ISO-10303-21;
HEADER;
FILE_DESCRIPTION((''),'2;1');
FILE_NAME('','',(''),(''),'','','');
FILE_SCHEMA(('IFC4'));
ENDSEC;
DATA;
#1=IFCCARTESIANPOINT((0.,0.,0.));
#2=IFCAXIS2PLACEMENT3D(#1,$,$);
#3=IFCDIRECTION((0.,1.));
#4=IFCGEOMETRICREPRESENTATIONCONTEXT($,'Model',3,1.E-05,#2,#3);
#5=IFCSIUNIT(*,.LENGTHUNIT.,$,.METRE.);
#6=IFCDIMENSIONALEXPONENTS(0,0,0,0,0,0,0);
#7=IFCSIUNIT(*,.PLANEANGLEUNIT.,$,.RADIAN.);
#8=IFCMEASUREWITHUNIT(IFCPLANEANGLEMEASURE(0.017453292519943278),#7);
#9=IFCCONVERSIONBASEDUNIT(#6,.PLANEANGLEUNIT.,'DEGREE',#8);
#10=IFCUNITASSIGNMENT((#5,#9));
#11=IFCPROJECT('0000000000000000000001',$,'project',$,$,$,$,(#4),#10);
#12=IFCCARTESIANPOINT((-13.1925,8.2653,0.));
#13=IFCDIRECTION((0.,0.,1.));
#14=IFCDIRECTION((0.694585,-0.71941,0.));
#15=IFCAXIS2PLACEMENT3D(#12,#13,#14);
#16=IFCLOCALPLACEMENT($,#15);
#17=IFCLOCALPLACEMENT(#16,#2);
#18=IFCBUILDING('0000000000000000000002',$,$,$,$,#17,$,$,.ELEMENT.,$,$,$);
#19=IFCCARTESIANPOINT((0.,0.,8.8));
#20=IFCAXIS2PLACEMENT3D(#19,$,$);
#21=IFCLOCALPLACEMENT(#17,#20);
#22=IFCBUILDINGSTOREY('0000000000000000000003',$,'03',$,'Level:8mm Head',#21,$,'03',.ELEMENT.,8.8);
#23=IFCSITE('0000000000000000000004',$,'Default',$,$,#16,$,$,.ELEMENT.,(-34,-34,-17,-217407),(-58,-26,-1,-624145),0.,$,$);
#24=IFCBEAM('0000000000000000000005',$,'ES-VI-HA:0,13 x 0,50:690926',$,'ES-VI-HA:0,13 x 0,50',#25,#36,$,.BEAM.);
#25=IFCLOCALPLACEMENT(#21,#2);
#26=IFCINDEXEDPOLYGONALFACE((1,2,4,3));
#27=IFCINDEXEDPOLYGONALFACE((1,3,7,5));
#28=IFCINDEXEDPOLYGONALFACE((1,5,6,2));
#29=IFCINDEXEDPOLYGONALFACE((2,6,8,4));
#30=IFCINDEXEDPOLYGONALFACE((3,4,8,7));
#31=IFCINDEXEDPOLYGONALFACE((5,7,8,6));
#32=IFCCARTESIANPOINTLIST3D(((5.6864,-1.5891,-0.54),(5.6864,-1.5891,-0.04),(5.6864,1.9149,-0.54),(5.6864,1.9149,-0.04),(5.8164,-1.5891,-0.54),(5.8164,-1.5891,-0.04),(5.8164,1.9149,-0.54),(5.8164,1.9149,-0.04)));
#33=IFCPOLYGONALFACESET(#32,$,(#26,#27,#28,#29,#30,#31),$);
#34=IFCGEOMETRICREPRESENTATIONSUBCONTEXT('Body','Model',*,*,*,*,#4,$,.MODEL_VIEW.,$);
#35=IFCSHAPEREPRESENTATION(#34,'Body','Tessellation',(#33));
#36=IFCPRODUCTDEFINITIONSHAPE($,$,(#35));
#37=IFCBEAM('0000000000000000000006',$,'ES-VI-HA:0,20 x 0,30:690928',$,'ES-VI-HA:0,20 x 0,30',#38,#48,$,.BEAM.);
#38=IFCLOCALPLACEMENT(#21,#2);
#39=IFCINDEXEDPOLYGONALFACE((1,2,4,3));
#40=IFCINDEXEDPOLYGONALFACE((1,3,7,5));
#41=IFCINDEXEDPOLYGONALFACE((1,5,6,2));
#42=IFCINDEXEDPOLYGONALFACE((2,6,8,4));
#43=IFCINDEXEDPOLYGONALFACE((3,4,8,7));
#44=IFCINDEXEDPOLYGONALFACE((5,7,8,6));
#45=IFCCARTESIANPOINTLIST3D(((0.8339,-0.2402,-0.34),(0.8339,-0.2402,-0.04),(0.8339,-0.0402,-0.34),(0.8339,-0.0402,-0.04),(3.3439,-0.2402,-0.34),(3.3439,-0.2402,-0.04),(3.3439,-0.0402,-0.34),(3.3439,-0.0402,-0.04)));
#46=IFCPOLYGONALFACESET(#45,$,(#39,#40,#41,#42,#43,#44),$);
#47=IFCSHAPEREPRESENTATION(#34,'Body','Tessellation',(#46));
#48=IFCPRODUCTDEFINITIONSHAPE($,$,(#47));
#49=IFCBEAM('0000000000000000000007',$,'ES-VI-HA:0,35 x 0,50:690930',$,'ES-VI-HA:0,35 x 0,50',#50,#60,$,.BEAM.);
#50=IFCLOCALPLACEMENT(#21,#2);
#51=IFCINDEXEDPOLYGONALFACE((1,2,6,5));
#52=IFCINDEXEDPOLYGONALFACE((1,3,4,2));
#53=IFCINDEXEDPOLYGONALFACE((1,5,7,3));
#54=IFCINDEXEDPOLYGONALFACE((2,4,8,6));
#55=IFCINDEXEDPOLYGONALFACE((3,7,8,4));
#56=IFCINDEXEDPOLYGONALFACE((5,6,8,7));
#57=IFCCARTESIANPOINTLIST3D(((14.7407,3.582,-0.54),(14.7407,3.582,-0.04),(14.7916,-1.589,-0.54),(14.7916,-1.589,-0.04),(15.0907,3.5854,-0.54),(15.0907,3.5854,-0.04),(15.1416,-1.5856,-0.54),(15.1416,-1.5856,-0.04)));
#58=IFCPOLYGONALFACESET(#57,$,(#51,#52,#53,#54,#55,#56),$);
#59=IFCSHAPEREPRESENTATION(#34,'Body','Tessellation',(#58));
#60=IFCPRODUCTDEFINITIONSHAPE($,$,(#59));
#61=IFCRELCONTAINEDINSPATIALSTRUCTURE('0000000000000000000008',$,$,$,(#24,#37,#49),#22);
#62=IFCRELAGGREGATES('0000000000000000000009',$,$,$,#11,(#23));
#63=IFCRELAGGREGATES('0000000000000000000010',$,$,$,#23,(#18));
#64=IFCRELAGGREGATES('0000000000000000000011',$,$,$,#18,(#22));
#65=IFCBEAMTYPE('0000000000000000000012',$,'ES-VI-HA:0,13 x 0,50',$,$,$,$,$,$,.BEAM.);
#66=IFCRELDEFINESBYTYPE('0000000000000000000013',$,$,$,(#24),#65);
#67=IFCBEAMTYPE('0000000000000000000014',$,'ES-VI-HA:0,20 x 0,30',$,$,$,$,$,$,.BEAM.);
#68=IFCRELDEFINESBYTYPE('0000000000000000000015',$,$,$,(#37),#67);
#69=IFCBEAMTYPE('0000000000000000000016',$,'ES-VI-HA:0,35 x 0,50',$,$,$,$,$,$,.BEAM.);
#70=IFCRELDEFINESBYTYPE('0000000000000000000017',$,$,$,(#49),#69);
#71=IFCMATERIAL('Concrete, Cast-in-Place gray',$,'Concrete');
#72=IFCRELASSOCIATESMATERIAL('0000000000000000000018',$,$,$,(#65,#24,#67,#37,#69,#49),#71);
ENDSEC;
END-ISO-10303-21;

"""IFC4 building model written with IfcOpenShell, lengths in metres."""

from ifc_helpers import new_model, entity, si_unit, converted_unit, direction, frame, origin, place, context, subcontext, project, spatial, indexed_curve, outline, extrude, source, transform, mapped, material, type_object, type_shapes, element, save


model = new_model("IFC4")

# Units and contexts
model_context = context("Model", 3, precision=1e-05, world=origin(), true_north=direction((0.0, 1.0)))
body_context = subcontext(model_context, "Body", "Model", "MODEL_VIEW")
ifc_project = project(units=[si_unit("LENGTHUNIT", "METRE"), converted_unit("PLANEANGLEUNIT", "DEGREE", entity("IfcPlaneAngleMeasure", 0.017453292519943278), si_unit("PLANEANGLEUNIT", "RADIAN"), dimensions=[0, 0, 0, 0, 0, 0, 0])], contexts=[model_context])

# Site, building, storey
site_placement = place(None, frame((-13.1925, 8.2653, 0.0), z_axis=(0.0, 0.0, 1.0), x_axis=(0.694585, -0.71941, 0.0)))
site = spatial("IfcSite", under=ifc_project, at=site_placement, Name="Default", CompositionType="ELEMENT", RefLatitude=(-34, -34, -17, -217407), RefLongitude=(-58, -26, -1, -624145), RefElevation=0.0)
building_placement = place(site_placement, origin())
building = spatial("IfcBuilding", under=site, at=building_placement, CompositionType="ELEMENT")
storey_placement = place(building_placement, frame((0.0, 0.0, 8.8)))
storey = spatial("IfcBuildingStorey", under=building, at=storey_placement, Name="03", ObjectType="Level:8mm Head", LongName="03", CompositionType="ELEMENT", Elevation=8.8)

# Beams
ifc_material = material(Name="Concrete, Cast-in-Place gray", Category="Concrete")
beam_type_1 = type_object("IfcBeamType", Name="ES-VI-HA:0,13 x 0,50", PredefinedType="BEAM", material=ifc_material)
shared_shape_1 = source(origin(), body_context, "Body", "SweptSolid", [
    extrude(outline(indexed_curve([(-0.065, -0.25), (0.065, -0.25), (0.065, 0.25), (-0.065, 0.25), (-0.065, -0.25)], self_intersect=False)), frame((5.7514, -1.5891, 8.51), z_axis=(0.0, 1.0, 0.0), x_axis=(-1.0, 0.0, 0.0)), (0.0, 0.0, 1.0), 3.5039),
])
type_shapes(beam_type_1, [shared_shape_1])
beam_1_placement = place(storey_placement, frame((0.0, 0.0, -8.8)))
element("IfcBeam", 1, at=beam_1_placement, inside=storey, type_object=beam_type_1, material=ifc_material, Name="ES-VI-HA:0,13 x 0,50:690926", ObjectType="ES-VI-HA:0,13 x 0,50", PredefinedType="BEAM", context=body_context, shape_type="MappedRepresentation", body=[
    mapped(shared_shape_1, transform((0.0, 0.0, 0.0), scale=1.0)),
])
beam_type_2 = type_object("IfcBeamType", Name="ES-VI-HA:0,20 x 0,30", PredefinedType="BEAM", material=ifc_material)
shared_shape_2 = source(origin(), body_context, "Body", "SweptSolid", [
    extrude(outline(indexed_curve([(-0.15, -0.1), (0.15, -0.1), (0.15, 0.1), (-0.15, 0.1), (-0.15, -0.1)], self_intersect=False)), frame((0.8339, -0.1402, 8.61), z_axis=(1.0, 0.0, 0.0), x_axis=(0.0, 0.0, -1.0)), (0.0, 0.0, 1.0), 2.51),
])
type_shapes(beam_type_2, [shared_shape_2])
beam_2_placement = place(storey_placement, frame((0.0, 0.0, -8.8)))
element("IfcBeam", 2, at=beam_2_placement, inside=storey, type_object=beam_type_2, material=ifc_material, Name="ES-VI-HA:0,20 x 0,30:690928", ObjectType="ES-VI-HA:0,20 x 0,30", PredefinedType="BEAM", context=body_context, shape_type="MappedRepresentation", body=[
    mapped(shared_shape_2, transform((0.0, 0.0, 0.0), scale=1.0)),
])
beam_type_3 = type_object("IfcBeamType", Name="ES-VI-HA:0,35 x 0,50", PredefinedType="BEAM", material=ifc_material)
shared_shape_3 = source(origin(), body_context, "Body", "SweptSolid", [
    extrude(outline(indexed_curve([(-0.25, -0.175), (0.25, -0.175), (0.25, 0.175), (-0.25, 0.175), (-0.25, -0.175)], self_intersect=False)), frame((14.9157, 3.5837, 8.51), z_axis=(0.009844, -0.999952, 0.0), x_axis=(0.0, 0.0, -1.0)), (0.0, 0.0, 1.0), 5.1713),
])
type_shapes(beam_type_3, [shared_shape_3])
beam_3_placement = place(storey_placement, frame((0.0, 0.0, -8.8)))
element("IfcBeam", 3, at=beam_3_placement, inside=storey, type_object=beam_type_3, material=ifc_material, Name="ES-VI-HA:0,35 x 0,50:690930", ObjectType="ES-VI-HA:0,35 x 0,50", PredefinedType="BEAM", context=body_context, shape_type="MappedRepresentation", body=[
    mapped(shared_shape_3, transform((0.0, 0.0, 0.0), scale=1.0)),
])

save(model, "model.ifc")
